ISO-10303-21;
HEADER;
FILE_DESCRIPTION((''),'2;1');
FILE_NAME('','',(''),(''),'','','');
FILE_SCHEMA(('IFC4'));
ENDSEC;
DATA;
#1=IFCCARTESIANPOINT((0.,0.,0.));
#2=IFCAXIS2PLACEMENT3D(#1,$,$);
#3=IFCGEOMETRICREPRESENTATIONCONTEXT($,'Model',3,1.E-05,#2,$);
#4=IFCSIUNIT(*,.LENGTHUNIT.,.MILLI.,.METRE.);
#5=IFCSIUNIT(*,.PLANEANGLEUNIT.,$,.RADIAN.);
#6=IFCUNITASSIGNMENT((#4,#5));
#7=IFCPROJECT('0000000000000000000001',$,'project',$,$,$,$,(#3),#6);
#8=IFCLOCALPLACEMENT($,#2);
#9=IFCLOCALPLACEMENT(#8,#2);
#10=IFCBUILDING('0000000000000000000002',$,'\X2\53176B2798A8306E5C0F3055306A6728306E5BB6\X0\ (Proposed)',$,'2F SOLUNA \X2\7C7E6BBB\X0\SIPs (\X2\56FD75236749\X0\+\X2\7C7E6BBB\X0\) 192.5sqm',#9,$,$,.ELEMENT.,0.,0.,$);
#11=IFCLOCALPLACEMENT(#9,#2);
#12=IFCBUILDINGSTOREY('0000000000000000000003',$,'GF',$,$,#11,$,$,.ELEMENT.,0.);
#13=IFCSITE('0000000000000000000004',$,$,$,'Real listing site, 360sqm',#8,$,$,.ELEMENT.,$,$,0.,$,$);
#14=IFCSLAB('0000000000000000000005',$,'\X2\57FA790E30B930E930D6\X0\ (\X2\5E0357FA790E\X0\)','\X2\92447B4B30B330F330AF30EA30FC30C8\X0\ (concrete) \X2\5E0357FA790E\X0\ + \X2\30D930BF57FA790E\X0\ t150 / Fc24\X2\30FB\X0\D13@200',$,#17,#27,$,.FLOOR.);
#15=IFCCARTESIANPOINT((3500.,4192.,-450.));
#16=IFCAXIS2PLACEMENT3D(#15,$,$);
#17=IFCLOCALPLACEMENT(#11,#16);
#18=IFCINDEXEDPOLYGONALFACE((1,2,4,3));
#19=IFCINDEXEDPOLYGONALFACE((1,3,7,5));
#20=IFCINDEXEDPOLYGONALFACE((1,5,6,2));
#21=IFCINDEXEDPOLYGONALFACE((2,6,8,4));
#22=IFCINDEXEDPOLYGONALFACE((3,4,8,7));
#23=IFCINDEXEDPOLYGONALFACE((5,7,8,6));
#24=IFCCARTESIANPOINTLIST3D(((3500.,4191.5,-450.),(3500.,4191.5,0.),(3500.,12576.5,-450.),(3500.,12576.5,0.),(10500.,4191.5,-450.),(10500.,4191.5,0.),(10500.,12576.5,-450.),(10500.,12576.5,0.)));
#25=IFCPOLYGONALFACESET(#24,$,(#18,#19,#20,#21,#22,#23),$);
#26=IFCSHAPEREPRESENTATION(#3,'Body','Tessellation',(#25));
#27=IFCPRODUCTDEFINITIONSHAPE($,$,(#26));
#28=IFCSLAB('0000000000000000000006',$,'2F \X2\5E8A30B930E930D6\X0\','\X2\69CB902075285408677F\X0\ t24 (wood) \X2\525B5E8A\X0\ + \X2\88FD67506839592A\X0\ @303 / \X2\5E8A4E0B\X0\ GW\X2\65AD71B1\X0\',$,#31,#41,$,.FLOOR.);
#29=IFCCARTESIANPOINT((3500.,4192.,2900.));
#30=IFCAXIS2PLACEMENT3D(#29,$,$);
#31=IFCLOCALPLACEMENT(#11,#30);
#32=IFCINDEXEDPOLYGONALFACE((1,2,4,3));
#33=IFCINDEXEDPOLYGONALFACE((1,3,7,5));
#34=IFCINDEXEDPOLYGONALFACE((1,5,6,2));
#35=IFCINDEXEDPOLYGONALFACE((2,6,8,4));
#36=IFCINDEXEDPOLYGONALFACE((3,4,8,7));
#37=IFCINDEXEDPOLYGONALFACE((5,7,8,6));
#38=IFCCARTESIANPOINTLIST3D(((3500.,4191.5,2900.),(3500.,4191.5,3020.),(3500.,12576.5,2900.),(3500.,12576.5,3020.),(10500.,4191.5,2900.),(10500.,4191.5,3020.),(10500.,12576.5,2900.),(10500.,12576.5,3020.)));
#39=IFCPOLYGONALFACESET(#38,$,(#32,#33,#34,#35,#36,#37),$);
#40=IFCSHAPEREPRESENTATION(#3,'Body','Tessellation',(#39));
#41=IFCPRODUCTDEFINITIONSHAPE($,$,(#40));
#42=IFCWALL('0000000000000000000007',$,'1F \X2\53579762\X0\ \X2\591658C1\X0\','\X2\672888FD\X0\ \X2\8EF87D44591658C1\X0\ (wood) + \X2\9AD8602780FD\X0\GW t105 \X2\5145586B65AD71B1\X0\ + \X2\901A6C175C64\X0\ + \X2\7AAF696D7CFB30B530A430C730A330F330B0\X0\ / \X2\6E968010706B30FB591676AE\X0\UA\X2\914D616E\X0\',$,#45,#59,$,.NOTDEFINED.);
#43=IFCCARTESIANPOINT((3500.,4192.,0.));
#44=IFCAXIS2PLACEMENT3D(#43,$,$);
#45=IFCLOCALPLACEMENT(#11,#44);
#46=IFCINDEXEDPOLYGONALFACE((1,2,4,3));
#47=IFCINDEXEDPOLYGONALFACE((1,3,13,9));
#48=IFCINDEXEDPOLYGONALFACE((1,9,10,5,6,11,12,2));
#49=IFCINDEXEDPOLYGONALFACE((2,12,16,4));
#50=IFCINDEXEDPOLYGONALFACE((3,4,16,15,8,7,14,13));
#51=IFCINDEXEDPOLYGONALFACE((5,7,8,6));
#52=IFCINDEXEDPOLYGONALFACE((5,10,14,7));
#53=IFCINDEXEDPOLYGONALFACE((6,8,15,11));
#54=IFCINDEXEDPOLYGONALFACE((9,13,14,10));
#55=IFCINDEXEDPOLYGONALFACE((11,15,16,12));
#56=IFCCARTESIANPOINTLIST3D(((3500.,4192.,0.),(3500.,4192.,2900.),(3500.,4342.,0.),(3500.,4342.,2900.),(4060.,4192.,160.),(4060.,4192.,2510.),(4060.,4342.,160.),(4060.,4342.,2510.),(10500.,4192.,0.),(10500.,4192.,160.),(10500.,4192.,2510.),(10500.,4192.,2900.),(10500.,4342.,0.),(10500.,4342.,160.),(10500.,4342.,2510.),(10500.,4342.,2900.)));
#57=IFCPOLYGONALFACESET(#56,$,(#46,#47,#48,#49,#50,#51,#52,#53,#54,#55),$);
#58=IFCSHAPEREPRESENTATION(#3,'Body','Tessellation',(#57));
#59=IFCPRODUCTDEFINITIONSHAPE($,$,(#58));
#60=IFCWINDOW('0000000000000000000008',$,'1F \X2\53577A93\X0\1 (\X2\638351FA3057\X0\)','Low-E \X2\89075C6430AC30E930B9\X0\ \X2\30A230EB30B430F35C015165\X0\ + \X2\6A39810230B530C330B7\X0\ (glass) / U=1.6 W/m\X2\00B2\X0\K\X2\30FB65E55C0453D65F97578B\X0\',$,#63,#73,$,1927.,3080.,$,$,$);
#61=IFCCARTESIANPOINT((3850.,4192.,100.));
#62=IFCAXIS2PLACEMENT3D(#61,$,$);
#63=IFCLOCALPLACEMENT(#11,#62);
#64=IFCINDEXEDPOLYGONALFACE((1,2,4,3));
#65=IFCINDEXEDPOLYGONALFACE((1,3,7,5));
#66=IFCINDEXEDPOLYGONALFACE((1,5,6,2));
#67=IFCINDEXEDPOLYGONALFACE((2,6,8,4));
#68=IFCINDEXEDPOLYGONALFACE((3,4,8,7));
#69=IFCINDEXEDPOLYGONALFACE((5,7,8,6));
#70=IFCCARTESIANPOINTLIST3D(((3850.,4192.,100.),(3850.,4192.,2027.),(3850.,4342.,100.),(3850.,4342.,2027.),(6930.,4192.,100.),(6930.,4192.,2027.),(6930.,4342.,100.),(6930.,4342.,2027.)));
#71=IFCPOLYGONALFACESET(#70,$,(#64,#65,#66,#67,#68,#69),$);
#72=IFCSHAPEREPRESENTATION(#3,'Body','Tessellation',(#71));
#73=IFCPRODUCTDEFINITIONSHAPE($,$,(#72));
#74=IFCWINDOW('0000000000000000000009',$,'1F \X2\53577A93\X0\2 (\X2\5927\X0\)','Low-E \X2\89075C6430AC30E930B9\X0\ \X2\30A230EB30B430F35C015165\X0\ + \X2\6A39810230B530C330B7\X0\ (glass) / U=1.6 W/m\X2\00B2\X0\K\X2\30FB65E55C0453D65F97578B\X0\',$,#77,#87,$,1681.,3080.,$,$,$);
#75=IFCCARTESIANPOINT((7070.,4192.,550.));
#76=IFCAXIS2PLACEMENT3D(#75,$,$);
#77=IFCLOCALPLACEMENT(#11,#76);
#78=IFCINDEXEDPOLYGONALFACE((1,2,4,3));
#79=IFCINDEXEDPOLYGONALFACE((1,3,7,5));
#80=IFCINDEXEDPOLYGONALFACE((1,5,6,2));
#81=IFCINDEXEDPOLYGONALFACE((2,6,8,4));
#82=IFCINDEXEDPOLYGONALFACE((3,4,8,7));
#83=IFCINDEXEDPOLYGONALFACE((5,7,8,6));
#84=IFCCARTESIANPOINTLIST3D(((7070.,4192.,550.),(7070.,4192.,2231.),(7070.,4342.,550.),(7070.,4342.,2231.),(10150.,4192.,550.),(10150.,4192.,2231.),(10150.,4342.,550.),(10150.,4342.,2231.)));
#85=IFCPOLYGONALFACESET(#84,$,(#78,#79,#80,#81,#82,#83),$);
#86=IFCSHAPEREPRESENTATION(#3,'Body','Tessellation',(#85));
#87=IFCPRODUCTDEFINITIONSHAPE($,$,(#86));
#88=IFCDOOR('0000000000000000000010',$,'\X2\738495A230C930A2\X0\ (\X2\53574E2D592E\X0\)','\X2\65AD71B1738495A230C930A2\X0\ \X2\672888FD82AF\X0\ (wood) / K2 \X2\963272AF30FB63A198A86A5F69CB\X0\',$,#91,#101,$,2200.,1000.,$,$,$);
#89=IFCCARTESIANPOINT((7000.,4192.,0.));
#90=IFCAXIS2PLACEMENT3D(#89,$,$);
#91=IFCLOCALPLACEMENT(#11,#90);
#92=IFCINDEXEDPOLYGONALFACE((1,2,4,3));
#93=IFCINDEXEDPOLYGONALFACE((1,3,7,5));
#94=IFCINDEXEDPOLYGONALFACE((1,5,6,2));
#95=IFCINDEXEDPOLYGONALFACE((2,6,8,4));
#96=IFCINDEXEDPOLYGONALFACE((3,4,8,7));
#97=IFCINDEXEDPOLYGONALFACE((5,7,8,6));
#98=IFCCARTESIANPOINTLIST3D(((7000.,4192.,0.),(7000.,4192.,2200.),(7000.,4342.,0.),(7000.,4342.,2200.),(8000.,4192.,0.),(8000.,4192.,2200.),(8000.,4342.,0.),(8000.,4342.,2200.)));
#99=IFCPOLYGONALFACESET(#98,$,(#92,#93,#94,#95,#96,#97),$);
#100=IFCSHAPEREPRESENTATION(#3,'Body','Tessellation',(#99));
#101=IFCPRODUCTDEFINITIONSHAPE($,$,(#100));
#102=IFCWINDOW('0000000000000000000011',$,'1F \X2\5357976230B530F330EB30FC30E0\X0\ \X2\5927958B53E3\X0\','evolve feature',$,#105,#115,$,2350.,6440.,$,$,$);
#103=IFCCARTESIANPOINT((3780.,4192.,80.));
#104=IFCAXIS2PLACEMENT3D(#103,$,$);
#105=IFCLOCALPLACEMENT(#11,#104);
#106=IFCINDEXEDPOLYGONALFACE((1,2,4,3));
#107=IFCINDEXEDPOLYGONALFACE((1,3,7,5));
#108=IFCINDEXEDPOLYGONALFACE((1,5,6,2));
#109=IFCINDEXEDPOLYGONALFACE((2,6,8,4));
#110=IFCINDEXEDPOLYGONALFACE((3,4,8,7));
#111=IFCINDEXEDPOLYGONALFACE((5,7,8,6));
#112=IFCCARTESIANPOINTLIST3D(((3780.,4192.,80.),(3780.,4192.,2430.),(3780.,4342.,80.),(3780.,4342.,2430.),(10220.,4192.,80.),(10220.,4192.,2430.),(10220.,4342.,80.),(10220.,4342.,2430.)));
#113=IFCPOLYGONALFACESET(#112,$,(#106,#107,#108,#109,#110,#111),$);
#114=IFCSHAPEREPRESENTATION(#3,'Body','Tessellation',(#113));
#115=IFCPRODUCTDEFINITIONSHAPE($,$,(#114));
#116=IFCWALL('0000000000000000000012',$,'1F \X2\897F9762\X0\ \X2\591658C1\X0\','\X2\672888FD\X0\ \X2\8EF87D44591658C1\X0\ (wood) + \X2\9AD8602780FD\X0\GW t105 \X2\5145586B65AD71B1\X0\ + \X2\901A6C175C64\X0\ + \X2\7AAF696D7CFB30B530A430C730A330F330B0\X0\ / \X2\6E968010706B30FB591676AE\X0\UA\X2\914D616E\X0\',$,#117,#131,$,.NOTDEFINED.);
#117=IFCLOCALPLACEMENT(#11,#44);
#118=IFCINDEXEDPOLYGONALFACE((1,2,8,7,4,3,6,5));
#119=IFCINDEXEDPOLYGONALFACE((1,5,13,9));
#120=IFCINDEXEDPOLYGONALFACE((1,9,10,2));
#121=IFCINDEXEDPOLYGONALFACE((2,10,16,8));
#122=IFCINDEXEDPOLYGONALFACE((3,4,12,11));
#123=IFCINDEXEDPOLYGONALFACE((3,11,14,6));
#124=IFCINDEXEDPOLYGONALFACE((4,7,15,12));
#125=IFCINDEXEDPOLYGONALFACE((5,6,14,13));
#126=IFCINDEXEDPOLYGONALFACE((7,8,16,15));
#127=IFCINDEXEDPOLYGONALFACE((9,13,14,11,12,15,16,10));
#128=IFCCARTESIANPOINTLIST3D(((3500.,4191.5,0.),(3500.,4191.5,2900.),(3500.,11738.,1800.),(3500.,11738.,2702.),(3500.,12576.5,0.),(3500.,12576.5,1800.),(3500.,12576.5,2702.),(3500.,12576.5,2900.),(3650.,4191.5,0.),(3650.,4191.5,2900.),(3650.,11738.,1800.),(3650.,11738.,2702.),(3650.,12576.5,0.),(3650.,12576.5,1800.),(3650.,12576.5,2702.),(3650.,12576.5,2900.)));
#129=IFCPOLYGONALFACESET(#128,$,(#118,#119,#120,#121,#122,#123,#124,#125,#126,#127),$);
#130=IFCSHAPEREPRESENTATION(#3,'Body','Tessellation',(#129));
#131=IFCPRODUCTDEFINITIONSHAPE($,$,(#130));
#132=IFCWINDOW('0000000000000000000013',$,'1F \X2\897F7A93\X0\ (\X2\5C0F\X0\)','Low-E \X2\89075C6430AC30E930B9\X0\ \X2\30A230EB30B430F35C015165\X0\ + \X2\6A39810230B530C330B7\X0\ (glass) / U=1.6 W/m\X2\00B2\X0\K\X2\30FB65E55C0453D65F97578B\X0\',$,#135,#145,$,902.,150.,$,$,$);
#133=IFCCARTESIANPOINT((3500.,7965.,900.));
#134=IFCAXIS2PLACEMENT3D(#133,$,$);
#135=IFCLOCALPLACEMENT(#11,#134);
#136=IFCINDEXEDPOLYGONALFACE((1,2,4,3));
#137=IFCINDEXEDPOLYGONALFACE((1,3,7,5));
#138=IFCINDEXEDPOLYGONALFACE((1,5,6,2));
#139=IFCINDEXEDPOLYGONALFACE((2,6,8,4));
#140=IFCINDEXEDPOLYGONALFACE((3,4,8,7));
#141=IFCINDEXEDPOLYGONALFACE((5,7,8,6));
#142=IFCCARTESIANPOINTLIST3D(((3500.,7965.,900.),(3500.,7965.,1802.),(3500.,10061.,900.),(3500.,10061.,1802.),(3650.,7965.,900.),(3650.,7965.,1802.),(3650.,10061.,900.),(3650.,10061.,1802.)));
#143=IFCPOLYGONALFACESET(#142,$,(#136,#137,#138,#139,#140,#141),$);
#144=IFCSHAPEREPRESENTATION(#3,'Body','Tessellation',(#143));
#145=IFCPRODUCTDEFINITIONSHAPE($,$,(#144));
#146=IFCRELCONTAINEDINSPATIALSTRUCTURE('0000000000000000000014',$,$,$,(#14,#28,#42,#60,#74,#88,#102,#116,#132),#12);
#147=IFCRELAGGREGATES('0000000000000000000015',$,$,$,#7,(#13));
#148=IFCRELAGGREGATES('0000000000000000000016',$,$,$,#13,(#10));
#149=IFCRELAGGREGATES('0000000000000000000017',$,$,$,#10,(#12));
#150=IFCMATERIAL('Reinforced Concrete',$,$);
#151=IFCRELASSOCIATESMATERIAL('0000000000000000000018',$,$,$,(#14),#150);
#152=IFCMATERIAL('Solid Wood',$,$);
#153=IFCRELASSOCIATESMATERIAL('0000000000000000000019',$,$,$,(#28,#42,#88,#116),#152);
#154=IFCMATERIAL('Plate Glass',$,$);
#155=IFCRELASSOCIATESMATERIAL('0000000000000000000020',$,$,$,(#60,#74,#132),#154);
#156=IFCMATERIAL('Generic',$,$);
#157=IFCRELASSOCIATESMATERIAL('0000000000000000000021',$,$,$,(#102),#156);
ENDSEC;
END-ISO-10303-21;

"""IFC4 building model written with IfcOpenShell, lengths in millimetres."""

from ifc_helpers import new_model, si_unit, frame, frame_2d, origin, place, context, project, spatial, rectangle, extrude, material, element, fill, save


model = new_model("IFC4")

# Units and contexts
model_context = context("Model", 3, precision=1e-05, world=origin())
ifc_project = project(units=[si_unit("LENGTHUNIT", "METRE", prefix="MILLI"), si_unit("PLANEANGLEUNIT", "RADIAN")], contexts=[model_context])

# Site, building, storey
site_placement = place(None, origin())
site = spatial("IfcSite", under=ifc_project, at=site_placement, ObjectType="Real listing site, 360sqm", CompositionType="ELEMENT", RefElevation=0.0)
building_placement = place(site_placement, origin())
building = spatial("IfcBuilding", under=site, at=building_placement, Name="北欧風の小さな木の家 (Proposed)", ObjectType="2F SOLUNA 籾殻SIPs (国産杉+籾殻) 192.5sqm", CompositionType="ELEMENT", ElevationOfRefHeight=0.0, ElevationOfTerrain=0.0)
storey_placement = place(building_placement, origin())
storey = spatial("IfcBuildingStorey", under=building, at=storey_placement, Name="GF", CompositionType="ELEMENT", Elevation=0.0)

# Slabs
ifc_material_1 = material(Name="Reinforced Concrete")
slab_1_placement = place(storey_placement, frame((3500.0, 4192.0, -450.0)))
element("IfcSlab", 1, at=slab_1_placement, inside=storey, material=ifc_material_1, Name="基礎スラブ (布基礎)", Description="鉄筋コンクリート (concrete) 布基礎 + ベタ基礎 t150 / Fc24・D13@200", PredefinedType="FLOOR", context=model_context, shape_type="SweptSolid", body=[
    extrude(rectangle(XDim=7000.0, YDim=8385.0, at=frame_2d((3500.0, 4192.0))), frame((3500.0, 4192.0, -450.0)), (0.0, 0.0, 1.0), 450.0),
])
ifc_material_2 = material(Name="Solid Wood")
slab_2_placement = place(storey_placement, frame((3500.0, 4192.0, 2900.0)))
element("IfcSlab", 2, at=slab_2_placement, inside=storey, material=ifc_material_2, Name="2F 床スラブ", Description="構造用合板 t24 (wood) 剛床 + 製材根太 @303 / 床下 GW断熱", PredefinedType="FLOOR", context=model_context, shape_type="SweptSolid", body=[
    extrude(rectangle(XDim=7000.0, YDim=8385.0, at=frame_2d((3500.0, 4192.0))), frame((3500.0, 4192.0, 2900.0)), (0.0, 0.0, 1.0), 120.0),
])

# Wall, openings, windows, door
wall_1_placement = place(storey_placement, frame((3500.0, 4192.0, 0.0)))
wall_1 = element("IfcWall", 3, at=wall_1_placement, inside=storey, material=ifc_material_2, Name="1F 南面 外壁", Description="木製 軸組外壁 (wood) + 高性能GW t105 充填断熱 + 通気層 + 窯業系サイディング / 準耐火・外皮UA配慮", PredefinedType="NOTDEFINED", context=model_context, shape_type="SweptSolid", body=[
    extrude(rectangle(XDim=7000.0, YDim=150.0, at=frame_2d((3500.0, 75.0))), frame((3500.0, 4192.0, 0.0)), (0.0, 0.0, 1.0), 2900.0),
])
opening_1_placement = place(storey_placement, frame((3850.0, 4192.0, 100.0)))
opening_1 = element("IfcOpeningElement", 4, at=opening_1_placement, cuts=wall_1, PredefinedType="NOTDEFINED", context=model_context, shape_type="SweptSolid", body=[
    extrude(rectangle(XDim=3080.0, YDim=150.0, at=frame_2d((1540.0, 75.0))), frame((3850.0, 4192.0, 100.0)), (0.0, 0.0, 1.0), 1927.0),
])
opening_2_placement = place(storey_placement, frame((7070.0, 4192.0, 550.0)))
opening_2 = element("IfcOpeningElement", 5, at=opening_2_placement, cuts=wall_1, PredefinedType="NOTDEFINED", context=model_context, shape_type="SweptSolid", body=[
    extrude(rectangle(XDim=3080.0, YDim=150.0, at=frame_2d((1540.0, 75.0))), frame((7070.0, 4192.0, 550.0)), (0.0, 0.0, 1.0), 1681.0),
])
opening_3_placement = place(storey_placement, frame((7000.0, 4192.0, 0.0)))
opening_3 = element("IfcOpeningElement", 6, at=opening_3_placement, cuts=wall_1, PredefinedType="NOTDEFINED", context=model_context, shape_type="SweptSolid", body=[
    extrude(rectangle(XDim=1000.0, YDim=150.0, at=frame_2d((500.0, 75.0))), frame((7000.0, 4192.0, 0.0)), (0.0, 0.0, 1.0), 2200.0),
])
opening_4_placement = place(storey_placement, frame((3780.0, 4192.0, 80.0)))
opening_4 = element("IfcOpeningElement", 7, at=opening_4_placement, cuts=wall_1, PredefinedType="NOTDEFINED", context=model_context, shape_type="SweptSolid", body=[
    extrude(rectangle(XDim=6440.0, YDim=150.0, at=frame_2d((3220.0, 75.0))), frame((3780.0, 4192.0, 80.0)), (0.0, 0.0, 1.0), 2350.0),
])
ifc_material_3 = material(Name="Plate Glass")
window_1_placement = place(storey_placement, frame((3850.0, 4192.0, 100.0)))
window_1 = element("IfcWindow", 8, at=window_1_placement, inside=storey, material=ifc_material_3, Name="1F 南窓1 (掃出し)", Description="Low-E 複層ガラス アルゴン封入 + 樹脂サッシ (glass) / U=1.6 W/m²K・日射取得型", OverallHeight=1927.0, OverallWidth=3080.0, context=model_context, shape_type="SweptSolid", body=[
    extrude(rectangle(XDim=3080.0, YDim=150.0, at=frame_2d((1540.0, 75.0))), frame((3850.0, 4192.0, 100.0)), (0.0, 0.0, 1.0), 1927.0),
])
fill(opening_1, window_1)
window_2_placement = place(storey_placement, frame((7070.0, 4192.0, 550.0)))
window_2 = element("IfcWindow", 9, at=window_2_placement, inside=storey, material=ifc_material_3, Name="1F 南窓2 (大)", Description="Low-E 複層ガラス アルゴン封入 + 樹脂サッシ (glass) / U=1.6 W/m²K・日射取得型", OverallHeight=1681.0, OverallWidth=3080.0, context=model_context, shape_type="SweptSolid", body=[
    extrude(rectangle(XDim=3080.0, YDim=150.0, at=frame_2d((1540.0, 75.0))), frame((7070.0, 4192.0, 550.0)), (0.0, 0.0, 1.0), 1681.0),
])
fill(opening_2, window_2)
door_placement = place(storey_placement, frame((7000.0, 4192.0, 0.0)))
door = element("IfcDoor", 10, at=door_placement, inside=storey, material=ifc_material_2, Name="玄関ドア (南中央)", Description="断熱玄関ドア 木製芯 (wood) / K2 防犯・採風機構", OverallHeight=2200.0, OverallWidth=1000.0, context=model_context, shape_type="SweptSolid", body=[
    extrude(rectangle(XDim=1000.0, YDim=150.0, at=frame_2d((500.0, 75.0))), frame((7000.0, 4192.0, 0.0)), (0.0, 0.0, 1.0), 2200.0),
])
fill(opening_3, door)
ifc_material_4 = material(Name="Generic")
window_3_placement = place(storey_placement, frame((3780.0, 4192.0, 80.0)))
window_3 = element("IfcWindow", 11, at=window_3_placement, inside=storey, material=ifc_material_4, Name="1F 南面サンルーム 大開口", Description="evolve feature", OverallHeight=2350.0, OverallWidth=6440.0, context=model_context, shape_type="SweptSolid", body=[
    extrude(rectangle(XDim=6440.0, YDim=150.0, at=frame_2d((3220.0, 75.0))), frame((3780.0, 4192.0, 80.0)), (0.0, 0.0, 1.0), 2350.0),
])
fill(opening_4, window_3)

# Wall, opening, window
wall_2_placement = place(storey_placement, frame((3500.0, 4192.0, 0.0)))
wall_2 = element("IfcWall", 12, at=wall_2_placement, inside=storey, material=ifc_material_2, Name="1F 西面 外壁", Description="木製 軸組外壁 (wood) + 高性能GW t105 充填断熱 + 通気層 + 窯業系サイディング / 準耐火・外皮UA配慮", PredefinedType="NOTDEFINED", context=model_context, shape_type="SweptSolid", body=[
    extrude(rectangle(XDim=150.0, YDim=8385.0, at=frame_2d((75.0, 4192.0))), frame((3500.0, 4192.0, 0.0)), (0.0, 0.0, 1.0), 2900.0),
])
opening_5_placement = place(storey_placement, frame((3500.0, 7965.0, 900.0)))
opening_5 = element("IfcOpeningElement", 13, at=opening_5_placement, cuts=wall_2, PredefinedType="NOTDEFINED", context=model_context, shape_type="SweptSolid", body=[
    extrude(rectangle(XDim=150.0, YDim=2096.0, at=frame_2d((75.0, 1048.0))), frame((3500.0, 7965.0, 900.0)), (0.0, 0.0, 1.0), 902.0),
])
window_4_placement = place(storey_placement, frame((3500.0, 7965.0, 900.0)))
window_4 = element("IfcWindow", 14, at=window_4_placement, inside=storey, material=ifc_material_3, Name="1F 西窓 (小)", Description="Low-E 複層ガラス アルゴン封入 + 樹脂サッシ (glass) / U=1.6 W/m²K・日射取得型", OverallHeight=902.0, OverallWidth=150.0, context=model_context, shape_type="SweptSolid", body=[
    extrude(rectangle(XDim=150.0, YDim=2096.0, at=frame_2d((75.0, 1048.0))), frame((3500.0, 7965.0, 900.0)), (0.0, 0.0, 1.0), 902.0),
])
fill(opening_5, window_4)

save(model, "model.ifc")
